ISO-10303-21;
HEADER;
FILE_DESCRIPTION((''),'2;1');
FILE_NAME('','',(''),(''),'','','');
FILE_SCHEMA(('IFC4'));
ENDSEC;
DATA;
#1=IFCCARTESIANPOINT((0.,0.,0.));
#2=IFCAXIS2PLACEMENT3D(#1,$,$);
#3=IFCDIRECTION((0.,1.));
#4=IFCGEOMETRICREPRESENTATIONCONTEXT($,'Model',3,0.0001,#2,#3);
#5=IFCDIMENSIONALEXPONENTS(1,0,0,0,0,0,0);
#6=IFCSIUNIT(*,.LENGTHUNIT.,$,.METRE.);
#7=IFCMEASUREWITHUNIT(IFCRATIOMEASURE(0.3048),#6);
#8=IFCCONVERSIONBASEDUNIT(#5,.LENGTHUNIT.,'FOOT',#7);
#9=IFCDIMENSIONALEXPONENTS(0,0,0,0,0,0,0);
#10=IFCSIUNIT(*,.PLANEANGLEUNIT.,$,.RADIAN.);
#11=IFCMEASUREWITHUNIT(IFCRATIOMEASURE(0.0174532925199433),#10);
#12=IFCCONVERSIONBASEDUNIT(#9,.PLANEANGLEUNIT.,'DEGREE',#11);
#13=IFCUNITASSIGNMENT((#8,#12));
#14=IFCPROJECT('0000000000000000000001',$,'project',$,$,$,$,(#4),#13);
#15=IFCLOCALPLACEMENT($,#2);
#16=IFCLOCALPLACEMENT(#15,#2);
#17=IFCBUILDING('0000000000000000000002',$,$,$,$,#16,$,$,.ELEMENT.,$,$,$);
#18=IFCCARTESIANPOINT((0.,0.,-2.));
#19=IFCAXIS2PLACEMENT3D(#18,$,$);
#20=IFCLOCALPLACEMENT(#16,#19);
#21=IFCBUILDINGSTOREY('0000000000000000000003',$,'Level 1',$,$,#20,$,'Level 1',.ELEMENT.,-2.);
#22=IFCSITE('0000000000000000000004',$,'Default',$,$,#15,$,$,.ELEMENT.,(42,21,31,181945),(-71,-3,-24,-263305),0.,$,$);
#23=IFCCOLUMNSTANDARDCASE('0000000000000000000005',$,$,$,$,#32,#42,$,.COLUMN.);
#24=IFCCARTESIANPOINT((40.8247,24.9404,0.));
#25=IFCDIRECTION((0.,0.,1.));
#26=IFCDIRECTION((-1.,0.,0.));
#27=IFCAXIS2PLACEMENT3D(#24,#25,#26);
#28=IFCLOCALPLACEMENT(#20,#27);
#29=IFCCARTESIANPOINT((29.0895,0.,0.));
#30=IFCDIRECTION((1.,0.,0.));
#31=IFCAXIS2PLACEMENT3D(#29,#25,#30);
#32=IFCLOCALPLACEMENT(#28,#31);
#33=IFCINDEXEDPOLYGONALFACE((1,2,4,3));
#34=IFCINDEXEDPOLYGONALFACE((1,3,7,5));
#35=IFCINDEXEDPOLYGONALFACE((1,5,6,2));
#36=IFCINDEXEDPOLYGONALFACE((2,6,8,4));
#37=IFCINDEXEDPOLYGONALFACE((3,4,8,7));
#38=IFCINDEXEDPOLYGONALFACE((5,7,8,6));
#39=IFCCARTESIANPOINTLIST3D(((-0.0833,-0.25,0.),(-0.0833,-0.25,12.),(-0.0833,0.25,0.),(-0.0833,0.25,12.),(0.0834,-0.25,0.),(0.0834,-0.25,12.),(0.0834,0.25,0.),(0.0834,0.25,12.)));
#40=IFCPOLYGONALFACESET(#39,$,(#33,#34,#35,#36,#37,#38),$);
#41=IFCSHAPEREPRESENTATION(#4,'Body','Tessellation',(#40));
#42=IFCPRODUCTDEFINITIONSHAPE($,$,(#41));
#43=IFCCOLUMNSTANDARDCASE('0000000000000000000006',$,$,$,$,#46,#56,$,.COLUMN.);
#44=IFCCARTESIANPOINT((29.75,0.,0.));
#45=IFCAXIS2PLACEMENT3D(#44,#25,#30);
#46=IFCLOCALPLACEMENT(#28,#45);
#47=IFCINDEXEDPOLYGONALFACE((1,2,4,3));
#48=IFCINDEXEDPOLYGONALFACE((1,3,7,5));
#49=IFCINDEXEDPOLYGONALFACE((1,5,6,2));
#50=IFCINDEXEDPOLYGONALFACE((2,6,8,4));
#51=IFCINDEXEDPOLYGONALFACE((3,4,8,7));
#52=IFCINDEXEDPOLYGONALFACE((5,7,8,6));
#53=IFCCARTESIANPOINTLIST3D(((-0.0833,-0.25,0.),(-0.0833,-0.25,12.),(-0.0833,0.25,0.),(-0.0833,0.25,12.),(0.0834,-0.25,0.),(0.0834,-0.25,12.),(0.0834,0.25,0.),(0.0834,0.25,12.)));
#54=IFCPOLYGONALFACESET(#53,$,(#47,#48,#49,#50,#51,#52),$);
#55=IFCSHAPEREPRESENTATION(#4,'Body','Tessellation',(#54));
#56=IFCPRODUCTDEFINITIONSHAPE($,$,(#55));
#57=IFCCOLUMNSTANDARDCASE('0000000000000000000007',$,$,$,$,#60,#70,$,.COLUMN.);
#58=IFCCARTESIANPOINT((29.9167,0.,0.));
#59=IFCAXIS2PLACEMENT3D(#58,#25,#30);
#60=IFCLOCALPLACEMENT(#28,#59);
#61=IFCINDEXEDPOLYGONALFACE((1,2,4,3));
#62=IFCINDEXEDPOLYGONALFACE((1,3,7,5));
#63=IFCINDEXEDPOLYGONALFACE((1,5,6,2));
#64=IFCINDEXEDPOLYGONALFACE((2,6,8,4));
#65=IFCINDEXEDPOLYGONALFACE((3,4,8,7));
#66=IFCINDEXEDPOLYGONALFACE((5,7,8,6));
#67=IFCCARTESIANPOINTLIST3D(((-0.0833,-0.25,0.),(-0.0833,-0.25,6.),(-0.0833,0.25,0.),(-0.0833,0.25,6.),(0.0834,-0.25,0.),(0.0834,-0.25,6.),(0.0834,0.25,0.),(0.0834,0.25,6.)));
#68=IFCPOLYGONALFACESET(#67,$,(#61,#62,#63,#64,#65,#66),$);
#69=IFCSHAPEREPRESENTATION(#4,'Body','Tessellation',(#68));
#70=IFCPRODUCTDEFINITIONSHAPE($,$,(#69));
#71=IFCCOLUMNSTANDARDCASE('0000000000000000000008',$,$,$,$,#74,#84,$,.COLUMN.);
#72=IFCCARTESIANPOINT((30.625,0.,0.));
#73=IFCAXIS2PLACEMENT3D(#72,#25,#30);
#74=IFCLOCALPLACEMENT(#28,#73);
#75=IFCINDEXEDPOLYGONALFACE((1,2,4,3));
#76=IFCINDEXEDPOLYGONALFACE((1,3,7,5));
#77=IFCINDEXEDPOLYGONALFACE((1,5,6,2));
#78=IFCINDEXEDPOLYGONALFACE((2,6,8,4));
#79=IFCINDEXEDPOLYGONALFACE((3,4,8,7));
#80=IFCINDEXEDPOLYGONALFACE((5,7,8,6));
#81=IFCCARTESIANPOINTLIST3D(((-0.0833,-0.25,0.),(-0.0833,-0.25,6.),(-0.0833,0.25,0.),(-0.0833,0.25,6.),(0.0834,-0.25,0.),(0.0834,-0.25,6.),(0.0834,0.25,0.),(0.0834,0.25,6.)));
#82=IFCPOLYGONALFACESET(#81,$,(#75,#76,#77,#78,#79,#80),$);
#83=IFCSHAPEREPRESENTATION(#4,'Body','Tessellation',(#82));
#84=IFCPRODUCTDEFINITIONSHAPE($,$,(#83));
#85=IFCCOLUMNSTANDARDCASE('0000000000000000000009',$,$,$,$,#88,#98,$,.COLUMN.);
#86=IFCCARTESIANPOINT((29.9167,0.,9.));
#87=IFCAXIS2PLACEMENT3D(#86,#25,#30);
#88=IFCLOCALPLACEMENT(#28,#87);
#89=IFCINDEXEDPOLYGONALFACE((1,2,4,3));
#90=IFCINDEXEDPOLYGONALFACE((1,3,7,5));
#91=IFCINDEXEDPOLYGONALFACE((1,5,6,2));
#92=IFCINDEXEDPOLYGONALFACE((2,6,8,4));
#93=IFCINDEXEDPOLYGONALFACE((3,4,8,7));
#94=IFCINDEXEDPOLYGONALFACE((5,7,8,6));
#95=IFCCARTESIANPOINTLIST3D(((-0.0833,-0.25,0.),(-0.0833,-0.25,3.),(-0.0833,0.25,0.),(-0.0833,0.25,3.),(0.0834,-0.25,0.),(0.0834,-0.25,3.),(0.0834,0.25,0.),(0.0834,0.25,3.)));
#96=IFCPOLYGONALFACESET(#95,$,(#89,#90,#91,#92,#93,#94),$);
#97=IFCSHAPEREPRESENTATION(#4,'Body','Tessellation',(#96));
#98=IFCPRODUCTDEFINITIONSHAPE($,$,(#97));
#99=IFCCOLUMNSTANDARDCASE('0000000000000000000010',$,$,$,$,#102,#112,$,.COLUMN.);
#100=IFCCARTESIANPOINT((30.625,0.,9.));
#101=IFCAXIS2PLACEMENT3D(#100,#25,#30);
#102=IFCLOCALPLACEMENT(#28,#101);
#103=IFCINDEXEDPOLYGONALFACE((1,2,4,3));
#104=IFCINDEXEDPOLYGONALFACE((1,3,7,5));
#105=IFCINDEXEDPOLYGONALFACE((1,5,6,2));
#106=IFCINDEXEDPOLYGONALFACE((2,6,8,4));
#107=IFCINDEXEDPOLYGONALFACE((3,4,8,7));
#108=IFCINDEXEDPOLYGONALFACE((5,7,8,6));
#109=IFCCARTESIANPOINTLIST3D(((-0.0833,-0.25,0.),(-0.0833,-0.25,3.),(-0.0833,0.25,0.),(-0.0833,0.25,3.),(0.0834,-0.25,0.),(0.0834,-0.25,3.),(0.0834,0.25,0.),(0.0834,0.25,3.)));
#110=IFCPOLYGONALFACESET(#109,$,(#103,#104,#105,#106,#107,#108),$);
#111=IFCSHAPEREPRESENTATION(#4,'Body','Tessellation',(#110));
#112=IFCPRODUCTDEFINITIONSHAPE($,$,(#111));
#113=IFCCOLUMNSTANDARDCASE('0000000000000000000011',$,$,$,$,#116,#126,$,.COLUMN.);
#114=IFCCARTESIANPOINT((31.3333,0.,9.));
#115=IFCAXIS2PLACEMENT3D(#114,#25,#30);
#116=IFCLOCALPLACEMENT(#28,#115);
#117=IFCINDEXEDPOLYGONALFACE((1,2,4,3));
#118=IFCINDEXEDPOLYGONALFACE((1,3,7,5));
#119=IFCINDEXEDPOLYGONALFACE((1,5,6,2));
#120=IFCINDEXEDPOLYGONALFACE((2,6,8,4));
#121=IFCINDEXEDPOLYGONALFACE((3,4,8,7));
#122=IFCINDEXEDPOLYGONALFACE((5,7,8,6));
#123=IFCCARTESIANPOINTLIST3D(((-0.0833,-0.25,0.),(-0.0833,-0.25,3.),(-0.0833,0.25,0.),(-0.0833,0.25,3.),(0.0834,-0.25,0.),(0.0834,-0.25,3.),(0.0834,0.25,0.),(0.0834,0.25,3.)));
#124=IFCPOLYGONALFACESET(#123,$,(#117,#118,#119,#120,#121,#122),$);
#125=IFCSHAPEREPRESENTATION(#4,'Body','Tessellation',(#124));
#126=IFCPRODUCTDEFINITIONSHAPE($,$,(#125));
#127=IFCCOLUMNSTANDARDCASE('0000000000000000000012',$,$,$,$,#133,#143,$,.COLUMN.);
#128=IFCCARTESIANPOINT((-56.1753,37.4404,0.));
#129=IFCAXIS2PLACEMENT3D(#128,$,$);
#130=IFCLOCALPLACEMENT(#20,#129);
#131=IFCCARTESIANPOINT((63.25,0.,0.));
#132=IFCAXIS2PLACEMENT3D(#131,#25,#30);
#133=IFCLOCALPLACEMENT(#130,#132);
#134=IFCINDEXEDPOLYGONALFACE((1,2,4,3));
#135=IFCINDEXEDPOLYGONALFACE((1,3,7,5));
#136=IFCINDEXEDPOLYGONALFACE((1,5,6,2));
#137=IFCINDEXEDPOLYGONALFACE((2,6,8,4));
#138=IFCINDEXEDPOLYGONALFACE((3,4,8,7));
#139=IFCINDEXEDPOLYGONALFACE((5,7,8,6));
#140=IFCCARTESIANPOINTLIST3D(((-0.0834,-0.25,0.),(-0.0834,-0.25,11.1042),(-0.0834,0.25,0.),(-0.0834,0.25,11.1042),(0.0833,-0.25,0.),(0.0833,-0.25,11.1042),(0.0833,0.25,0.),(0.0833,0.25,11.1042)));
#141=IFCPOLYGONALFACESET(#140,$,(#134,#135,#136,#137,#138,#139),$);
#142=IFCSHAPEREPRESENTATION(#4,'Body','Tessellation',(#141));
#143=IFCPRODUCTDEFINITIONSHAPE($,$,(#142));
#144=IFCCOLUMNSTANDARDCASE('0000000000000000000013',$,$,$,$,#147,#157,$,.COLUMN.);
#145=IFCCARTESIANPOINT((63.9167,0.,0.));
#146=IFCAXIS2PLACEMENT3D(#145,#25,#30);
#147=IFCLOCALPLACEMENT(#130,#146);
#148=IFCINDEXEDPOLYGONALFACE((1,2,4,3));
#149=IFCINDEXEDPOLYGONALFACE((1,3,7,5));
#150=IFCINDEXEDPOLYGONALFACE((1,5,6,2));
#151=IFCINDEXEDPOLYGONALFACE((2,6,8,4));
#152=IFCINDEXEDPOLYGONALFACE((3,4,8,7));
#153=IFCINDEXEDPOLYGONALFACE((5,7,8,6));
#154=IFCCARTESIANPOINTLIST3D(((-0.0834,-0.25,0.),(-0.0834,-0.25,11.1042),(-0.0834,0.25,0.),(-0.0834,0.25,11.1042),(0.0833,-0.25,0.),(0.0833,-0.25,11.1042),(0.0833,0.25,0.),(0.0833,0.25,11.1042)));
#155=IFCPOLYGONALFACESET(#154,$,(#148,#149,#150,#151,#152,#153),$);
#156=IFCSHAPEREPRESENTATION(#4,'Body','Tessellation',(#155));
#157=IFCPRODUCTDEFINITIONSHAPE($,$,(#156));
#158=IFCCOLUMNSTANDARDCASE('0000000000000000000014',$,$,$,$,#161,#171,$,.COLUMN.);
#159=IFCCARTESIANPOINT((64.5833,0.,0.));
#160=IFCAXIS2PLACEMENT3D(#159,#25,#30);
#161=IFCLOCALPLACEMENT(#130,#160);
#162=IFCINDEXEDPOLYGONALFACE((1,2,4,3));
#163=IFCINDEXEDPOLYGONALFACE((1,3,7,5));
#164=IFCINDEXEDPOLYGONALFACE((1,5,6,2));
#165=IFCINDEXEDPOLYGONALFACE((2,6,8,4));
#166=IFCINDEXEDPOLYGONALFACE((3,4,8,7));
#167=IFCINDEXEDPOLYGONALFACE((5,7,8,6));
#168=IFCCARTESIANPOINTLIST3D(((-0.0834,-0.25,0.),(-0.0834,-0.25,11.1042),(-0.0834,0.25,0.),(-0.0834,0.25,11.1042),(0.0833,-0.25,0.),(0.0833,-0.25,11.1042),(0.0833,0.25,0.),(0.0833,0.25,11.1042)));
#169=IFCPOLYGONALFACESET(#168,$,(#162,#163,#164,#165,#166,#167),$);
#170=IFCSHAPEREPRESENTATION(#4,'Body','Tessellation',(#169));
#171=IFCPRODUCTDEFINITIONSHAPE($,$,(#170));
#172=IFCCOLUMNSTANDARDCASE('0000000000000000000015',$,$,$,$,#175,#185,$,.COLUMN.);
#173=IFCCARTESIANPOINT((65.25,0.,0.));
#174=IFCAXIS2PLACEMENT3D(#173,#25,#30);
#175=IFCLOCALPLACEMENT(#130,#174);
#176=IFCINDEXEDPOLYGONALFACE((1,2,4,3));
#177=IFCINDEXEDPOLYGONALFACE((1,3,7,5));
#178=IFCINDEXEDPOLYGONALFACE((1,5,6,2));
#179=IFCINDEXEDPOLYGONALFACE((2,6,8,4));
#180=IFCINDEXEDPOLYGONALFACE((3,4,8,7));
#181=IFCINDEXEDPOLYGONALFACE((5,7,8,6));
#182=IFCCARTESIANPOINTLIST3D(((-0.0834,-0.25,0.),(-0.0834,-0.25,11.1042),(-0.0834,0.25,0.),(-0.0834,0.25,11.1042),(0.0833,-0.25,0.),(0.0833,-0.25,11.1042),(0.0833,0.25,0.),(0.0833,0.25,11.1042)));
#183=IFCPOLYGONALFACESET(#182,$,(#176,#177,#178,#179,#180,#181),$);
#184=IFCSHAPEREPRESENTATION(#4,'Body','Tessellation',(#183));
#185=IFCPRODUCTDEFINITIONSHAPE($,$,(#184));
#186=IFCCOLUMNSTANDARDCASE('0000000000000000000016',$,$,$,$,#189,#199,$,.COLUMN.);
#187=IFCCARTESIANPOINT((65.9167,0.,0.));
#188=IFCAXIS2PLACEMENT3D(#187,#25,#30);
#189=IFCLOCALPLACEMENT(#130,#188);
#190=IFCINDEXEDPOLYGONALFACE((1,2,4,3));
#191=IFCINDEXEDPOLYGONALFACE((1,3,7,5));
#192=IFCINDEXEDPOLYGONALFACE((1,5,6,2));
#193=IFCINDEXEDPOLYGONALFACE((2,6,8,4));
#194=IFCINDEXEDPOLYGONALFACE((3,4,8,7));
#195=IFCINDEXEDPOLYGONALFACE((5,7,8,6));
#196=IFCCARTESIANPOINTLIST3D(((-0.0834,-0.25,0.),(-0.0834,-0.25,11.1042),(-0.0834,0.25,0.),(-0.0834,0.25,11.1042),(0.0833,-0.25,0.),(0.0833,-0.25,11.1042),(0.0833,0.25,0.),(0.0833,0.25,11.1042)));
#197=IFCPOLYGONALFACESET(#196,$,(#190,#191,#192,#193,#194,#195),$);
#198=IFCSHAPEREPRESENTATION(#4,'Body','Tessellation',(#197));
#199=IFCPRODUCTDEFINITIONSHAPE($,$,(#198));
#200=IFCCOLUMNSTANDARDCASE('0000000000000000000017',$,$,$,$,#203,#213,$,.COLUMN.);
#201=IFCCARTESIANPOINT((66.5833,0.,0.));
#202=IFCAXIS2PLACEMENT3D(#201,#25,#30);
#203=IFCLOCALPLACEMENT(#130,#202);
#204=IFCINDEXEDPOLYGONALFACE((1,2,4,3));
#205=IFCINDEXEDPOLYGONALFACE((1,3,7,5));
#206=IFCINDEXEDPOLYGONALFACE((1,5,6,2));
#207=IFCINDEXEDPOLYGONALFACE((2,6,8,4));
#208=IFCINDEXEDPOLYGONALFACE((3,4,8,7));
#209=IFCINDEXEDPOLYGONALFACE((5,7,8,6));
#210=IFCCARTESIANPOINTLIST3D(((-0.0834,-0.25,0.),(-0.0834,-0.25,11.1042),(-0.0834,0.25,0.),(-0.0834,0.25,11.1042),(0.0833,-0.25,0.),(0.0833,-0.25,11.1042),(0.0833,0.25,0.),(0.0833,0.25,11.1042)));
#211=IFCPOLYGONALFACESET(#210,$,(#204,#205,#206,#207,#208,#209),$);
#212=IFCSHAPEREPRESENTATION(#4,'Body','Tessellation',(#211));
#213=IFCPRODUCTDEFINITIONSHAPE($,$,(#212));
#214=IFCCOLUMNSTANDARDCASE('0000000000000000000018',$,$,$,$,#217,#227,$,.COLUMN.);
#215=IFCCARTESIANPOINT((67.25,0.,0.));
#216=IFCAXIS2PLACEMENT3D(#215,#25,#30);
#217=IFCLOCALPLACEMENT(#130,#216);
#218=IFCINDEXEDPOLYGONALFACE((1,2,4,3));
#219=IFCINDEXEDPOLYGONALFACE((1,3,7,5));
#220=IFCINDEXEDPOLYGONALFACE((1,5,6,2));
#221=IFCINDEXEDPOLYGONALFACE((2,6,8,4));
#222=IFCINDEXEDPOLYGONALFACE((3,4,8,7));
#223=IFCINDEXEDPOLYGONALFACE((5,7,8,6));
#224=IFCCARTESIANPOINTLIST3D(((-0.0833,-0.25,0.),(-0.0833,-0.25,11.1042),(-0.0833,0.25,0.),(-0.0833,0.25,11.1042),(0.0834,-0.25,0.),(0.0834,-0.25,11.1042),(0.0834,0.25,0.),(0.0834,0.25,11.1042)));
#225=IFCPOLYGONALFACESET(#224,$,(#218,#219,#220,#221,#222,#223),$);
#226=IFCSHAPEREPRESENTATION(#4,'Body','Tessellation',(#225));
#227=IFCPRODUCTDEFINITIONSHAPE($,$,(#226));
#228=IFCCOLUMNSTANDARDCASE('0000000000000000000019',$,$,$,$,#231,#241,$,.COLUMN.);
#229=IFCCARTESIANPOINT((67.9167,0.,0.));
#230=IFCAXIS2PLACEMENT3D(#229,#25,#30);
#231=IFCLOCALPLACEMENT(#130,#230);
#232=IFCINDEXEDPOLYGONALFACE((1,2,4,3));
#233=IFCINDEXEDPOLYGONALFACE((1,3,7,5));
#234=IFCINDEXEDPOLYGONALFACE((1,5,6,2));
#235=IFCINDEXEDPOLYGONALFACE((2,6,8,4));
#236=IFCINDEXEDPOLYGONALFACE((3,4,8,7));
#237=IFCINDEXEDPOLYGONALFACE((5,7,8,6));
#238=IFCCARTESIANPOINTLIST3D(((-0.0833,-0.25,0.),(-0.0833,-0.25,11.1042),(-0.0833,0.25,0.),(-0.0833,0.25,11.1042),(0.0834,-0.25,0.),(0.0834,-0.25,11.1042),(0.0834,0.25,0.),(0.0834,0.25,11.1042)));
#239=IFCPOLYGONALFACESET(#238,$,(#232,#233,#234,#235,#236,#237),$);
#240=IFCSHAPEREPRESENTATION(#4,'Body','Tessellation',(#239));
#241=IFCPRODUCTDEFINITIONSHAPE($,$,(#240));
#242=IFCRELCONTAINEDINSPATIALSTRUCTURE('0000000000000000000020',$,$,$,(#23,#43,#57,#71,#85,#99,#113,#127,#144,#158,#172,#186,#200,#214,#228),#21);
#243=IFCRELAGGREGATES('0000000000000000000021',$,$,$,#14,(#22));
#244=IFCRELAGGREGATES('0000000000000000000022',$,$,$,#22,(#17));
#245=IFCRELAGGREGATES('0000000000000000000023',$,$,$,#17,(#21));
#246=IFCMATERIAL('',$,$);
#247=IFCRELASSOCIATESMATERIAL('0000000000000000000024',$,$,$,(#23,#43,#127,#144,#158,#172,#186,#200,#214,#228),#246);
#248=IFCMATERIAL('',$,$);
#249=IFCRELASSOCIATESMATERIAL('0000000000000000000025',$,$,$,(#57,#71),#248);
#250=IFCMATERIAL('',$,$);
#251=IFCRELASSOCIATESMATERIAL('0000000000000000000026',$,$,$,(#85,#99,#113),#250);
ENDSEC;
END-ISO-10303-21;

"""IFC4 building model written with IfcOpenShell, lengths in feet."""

from ifc_helpers import new_model, entity, si_unit, converted_unit, direction, frame, origin, place, context, project, spatial, rectangle, extrude, material, element, save


model = new_model("IFC4")

# Units and contexts
model_context = context("Model", 3, precision=0.0001, world=origin(), true_north=direction((0.0, 1.0)))
ifc_project = project(units=[converted_unit("LENGTHUNIT", "FOOT", entity("IfcRatioMeasure", 0.3048), si_unit("LENGTHUNIT", "METRE"), dimensions=[1, 0, 0, 0, 0, 0, 0]), converted_unit("PLANEANGLEUNIT", "DEGREE", entity("IfcRatioMeasure", 0.0174532925199433), si_unit("PLANEANGLEUNIT", "RADIAN"), dimensions=[0, 0, 0, 0, 0, 0, 0])], contexts=[model_context])

# Site, building, storey
site_placement = place(None, origin())
site = spatial("IfcSite", under=ifc_project, at=site_placement, Name="Default", CompositionType="ELEMENT", RefLatitude=(42, 21, 31, 181945), RefLongitude=(-71, -3, -24, -263305), RefElevation=0.0)
building_placement = place(site_placement, origin())
building = spatial("IfcBuilding", under=site, at=building_placement, CompositionType="ELEMENT")
storey_placement = place(building_placement, frame((0.0, 0.0, -2.0)))
storey = spatial("IfcBuildingStorey", under=building, at=storey_placement, Name="Level 1", LongName="Level 1", CompositionType="ELEMENT", Elevation=-2.0)

# Columns
ifc_material_1 = material(Name="")
placement_1 = place(storey_placement, frame((40.8247, 24.9404, 0.0), z_axis=(0.0, 0.0, 1.0), x_axis=(-1.0, 0.0, 0.0)))
for number, where, z_axis, x_axis in (
    (1, (29.0895, 0.0, 0.0), (0.0, 0.0, 1.0), (1.0, 0.0, 0.0)),
    (2, (29.75, 0.0, 0.0), (0.0, 0.0, 1.0), (1.0, 0.0, 0.0)),
):
    element("IfcColumnStandardCase", number, at=place(placement_1, frame(where, z_axis=z_axis, x_axis=x_axis)), inside=storey, material=ifc_material_1, PredefinedType="COLUMN", context=model_context, shape_type="SweptSolid", body=[
        extrude(rectangle(XDim=0.1667, YDim=0.5), origin(), (0.0, 0.0, 1.0), 12.0),
    ])
ifc_material_2 = material(Name="")
for number, where, z_axis, x_axis in (
    (3, (29.9167, 0.0, 0.0), (0.0, 0.0, 1.0), (1.0, 0.0, 0.0)),
    (4, (30.625, 0.0, 0.0), (0.0, 0.0, 1.0), (1.0, 0.0, 0.0)),
):
    element("IfcColumnStandardCase", number, at=place(placement_1, frame(where, z_axis=z_axis, x_axis=x_axis)), inside=storey, material=ifc_material_2, PredefinedType="COLUMN", context=model_context, shape_type="SweptSolid", body=[
        extrude(rectangle(XDim=0.1667, YDim=0.5), origin(), (0.0, 0.0, 1.0), 6.0),
    ])
ifc_material_3 = material(Name="")
for number, where, z_axis, x_axis in (
    (5, (29.9167, 0.0, 9.0), (0.0, 0.0, 1.0), (1.0, 0.0, 0.0)),
    (6, (30.625, 0.0, 9.0), (0.0, 0.0, 1.0), (1.0, 0.0, 0.0)),
    (7, (31.3333, 0.0, 9.0), (0.0, 0.0, 1.0), (1.0, 0.0, 0.0)),
):
    element("IfcColumnStandardCase", number, at=place(placement_1, frame(where, z_axis=z_axis, x_axis=x_axis)), inside=storey, material=ifc_material_3, PredefinedType="COLUMN", context=model_context, shape_type="SweptSolid", body=[
        extrude(rectangle(XDim=0.1667, YDim=0.5), origin(), (0.0, 0.0, 1.0), 3.0),
    ])
placement_2 = place(storey_placement, frame((-56.1753, 37.4404, 0.0)))
for number, where, z_axis, x_axis in (
    (8, (63.25, 0.0, 0.0), (0.0, 0.0, 1.0), (1.0, 0.0, 0.0)),
    (9, (63.9167, 0.0, 0.0), (0.0, 0.0, 1.0), (1.0, 0.0, 0.0)),
    (10, (64.5833, 0.0, 0.0), (0.0, 0.0, 1.0), (1.0, 0.0, 0.0)),
    (11, (65.25, 0.0, 0.0), (0.0, 0.0, 1.0), (1.0, 0.0, 0.0)),
    (12, (65.9167, 0.0, 0.0), (0.0, 0.0, 1.0), (1.0, 0.0, 0.0)),
    (13, (66.5833, 0.0, 0.0), (0.0, 0.0, 1.0), (1.0, 0.0, 0.0)),
    (14, (67.25, 0.0, 0.0), (0.0, 0.0, 1.0), (1.0, 0.0, 0.0)),
    (15, (67.9167, 0.0, 0.0), (0.0, 0.0, 1.0), (1.0, 0.0, 0.0)),
):
    element("IfcColumnStandardCase", number, at=place(placement_2, frame(where, z_axis=z_axis, x_axis=x_axis)), inside=storey, material=ifc_material_1, PredefinedType="COLUMN", context=model_context, shape_type="SweptSolid", body=[
        extrude(rectangle(XDim=0.1667, YDim=0.5), origin(), (0.0, 0.0, 1.0), 11.1042),
    ])

save(model, "model.ifc")
